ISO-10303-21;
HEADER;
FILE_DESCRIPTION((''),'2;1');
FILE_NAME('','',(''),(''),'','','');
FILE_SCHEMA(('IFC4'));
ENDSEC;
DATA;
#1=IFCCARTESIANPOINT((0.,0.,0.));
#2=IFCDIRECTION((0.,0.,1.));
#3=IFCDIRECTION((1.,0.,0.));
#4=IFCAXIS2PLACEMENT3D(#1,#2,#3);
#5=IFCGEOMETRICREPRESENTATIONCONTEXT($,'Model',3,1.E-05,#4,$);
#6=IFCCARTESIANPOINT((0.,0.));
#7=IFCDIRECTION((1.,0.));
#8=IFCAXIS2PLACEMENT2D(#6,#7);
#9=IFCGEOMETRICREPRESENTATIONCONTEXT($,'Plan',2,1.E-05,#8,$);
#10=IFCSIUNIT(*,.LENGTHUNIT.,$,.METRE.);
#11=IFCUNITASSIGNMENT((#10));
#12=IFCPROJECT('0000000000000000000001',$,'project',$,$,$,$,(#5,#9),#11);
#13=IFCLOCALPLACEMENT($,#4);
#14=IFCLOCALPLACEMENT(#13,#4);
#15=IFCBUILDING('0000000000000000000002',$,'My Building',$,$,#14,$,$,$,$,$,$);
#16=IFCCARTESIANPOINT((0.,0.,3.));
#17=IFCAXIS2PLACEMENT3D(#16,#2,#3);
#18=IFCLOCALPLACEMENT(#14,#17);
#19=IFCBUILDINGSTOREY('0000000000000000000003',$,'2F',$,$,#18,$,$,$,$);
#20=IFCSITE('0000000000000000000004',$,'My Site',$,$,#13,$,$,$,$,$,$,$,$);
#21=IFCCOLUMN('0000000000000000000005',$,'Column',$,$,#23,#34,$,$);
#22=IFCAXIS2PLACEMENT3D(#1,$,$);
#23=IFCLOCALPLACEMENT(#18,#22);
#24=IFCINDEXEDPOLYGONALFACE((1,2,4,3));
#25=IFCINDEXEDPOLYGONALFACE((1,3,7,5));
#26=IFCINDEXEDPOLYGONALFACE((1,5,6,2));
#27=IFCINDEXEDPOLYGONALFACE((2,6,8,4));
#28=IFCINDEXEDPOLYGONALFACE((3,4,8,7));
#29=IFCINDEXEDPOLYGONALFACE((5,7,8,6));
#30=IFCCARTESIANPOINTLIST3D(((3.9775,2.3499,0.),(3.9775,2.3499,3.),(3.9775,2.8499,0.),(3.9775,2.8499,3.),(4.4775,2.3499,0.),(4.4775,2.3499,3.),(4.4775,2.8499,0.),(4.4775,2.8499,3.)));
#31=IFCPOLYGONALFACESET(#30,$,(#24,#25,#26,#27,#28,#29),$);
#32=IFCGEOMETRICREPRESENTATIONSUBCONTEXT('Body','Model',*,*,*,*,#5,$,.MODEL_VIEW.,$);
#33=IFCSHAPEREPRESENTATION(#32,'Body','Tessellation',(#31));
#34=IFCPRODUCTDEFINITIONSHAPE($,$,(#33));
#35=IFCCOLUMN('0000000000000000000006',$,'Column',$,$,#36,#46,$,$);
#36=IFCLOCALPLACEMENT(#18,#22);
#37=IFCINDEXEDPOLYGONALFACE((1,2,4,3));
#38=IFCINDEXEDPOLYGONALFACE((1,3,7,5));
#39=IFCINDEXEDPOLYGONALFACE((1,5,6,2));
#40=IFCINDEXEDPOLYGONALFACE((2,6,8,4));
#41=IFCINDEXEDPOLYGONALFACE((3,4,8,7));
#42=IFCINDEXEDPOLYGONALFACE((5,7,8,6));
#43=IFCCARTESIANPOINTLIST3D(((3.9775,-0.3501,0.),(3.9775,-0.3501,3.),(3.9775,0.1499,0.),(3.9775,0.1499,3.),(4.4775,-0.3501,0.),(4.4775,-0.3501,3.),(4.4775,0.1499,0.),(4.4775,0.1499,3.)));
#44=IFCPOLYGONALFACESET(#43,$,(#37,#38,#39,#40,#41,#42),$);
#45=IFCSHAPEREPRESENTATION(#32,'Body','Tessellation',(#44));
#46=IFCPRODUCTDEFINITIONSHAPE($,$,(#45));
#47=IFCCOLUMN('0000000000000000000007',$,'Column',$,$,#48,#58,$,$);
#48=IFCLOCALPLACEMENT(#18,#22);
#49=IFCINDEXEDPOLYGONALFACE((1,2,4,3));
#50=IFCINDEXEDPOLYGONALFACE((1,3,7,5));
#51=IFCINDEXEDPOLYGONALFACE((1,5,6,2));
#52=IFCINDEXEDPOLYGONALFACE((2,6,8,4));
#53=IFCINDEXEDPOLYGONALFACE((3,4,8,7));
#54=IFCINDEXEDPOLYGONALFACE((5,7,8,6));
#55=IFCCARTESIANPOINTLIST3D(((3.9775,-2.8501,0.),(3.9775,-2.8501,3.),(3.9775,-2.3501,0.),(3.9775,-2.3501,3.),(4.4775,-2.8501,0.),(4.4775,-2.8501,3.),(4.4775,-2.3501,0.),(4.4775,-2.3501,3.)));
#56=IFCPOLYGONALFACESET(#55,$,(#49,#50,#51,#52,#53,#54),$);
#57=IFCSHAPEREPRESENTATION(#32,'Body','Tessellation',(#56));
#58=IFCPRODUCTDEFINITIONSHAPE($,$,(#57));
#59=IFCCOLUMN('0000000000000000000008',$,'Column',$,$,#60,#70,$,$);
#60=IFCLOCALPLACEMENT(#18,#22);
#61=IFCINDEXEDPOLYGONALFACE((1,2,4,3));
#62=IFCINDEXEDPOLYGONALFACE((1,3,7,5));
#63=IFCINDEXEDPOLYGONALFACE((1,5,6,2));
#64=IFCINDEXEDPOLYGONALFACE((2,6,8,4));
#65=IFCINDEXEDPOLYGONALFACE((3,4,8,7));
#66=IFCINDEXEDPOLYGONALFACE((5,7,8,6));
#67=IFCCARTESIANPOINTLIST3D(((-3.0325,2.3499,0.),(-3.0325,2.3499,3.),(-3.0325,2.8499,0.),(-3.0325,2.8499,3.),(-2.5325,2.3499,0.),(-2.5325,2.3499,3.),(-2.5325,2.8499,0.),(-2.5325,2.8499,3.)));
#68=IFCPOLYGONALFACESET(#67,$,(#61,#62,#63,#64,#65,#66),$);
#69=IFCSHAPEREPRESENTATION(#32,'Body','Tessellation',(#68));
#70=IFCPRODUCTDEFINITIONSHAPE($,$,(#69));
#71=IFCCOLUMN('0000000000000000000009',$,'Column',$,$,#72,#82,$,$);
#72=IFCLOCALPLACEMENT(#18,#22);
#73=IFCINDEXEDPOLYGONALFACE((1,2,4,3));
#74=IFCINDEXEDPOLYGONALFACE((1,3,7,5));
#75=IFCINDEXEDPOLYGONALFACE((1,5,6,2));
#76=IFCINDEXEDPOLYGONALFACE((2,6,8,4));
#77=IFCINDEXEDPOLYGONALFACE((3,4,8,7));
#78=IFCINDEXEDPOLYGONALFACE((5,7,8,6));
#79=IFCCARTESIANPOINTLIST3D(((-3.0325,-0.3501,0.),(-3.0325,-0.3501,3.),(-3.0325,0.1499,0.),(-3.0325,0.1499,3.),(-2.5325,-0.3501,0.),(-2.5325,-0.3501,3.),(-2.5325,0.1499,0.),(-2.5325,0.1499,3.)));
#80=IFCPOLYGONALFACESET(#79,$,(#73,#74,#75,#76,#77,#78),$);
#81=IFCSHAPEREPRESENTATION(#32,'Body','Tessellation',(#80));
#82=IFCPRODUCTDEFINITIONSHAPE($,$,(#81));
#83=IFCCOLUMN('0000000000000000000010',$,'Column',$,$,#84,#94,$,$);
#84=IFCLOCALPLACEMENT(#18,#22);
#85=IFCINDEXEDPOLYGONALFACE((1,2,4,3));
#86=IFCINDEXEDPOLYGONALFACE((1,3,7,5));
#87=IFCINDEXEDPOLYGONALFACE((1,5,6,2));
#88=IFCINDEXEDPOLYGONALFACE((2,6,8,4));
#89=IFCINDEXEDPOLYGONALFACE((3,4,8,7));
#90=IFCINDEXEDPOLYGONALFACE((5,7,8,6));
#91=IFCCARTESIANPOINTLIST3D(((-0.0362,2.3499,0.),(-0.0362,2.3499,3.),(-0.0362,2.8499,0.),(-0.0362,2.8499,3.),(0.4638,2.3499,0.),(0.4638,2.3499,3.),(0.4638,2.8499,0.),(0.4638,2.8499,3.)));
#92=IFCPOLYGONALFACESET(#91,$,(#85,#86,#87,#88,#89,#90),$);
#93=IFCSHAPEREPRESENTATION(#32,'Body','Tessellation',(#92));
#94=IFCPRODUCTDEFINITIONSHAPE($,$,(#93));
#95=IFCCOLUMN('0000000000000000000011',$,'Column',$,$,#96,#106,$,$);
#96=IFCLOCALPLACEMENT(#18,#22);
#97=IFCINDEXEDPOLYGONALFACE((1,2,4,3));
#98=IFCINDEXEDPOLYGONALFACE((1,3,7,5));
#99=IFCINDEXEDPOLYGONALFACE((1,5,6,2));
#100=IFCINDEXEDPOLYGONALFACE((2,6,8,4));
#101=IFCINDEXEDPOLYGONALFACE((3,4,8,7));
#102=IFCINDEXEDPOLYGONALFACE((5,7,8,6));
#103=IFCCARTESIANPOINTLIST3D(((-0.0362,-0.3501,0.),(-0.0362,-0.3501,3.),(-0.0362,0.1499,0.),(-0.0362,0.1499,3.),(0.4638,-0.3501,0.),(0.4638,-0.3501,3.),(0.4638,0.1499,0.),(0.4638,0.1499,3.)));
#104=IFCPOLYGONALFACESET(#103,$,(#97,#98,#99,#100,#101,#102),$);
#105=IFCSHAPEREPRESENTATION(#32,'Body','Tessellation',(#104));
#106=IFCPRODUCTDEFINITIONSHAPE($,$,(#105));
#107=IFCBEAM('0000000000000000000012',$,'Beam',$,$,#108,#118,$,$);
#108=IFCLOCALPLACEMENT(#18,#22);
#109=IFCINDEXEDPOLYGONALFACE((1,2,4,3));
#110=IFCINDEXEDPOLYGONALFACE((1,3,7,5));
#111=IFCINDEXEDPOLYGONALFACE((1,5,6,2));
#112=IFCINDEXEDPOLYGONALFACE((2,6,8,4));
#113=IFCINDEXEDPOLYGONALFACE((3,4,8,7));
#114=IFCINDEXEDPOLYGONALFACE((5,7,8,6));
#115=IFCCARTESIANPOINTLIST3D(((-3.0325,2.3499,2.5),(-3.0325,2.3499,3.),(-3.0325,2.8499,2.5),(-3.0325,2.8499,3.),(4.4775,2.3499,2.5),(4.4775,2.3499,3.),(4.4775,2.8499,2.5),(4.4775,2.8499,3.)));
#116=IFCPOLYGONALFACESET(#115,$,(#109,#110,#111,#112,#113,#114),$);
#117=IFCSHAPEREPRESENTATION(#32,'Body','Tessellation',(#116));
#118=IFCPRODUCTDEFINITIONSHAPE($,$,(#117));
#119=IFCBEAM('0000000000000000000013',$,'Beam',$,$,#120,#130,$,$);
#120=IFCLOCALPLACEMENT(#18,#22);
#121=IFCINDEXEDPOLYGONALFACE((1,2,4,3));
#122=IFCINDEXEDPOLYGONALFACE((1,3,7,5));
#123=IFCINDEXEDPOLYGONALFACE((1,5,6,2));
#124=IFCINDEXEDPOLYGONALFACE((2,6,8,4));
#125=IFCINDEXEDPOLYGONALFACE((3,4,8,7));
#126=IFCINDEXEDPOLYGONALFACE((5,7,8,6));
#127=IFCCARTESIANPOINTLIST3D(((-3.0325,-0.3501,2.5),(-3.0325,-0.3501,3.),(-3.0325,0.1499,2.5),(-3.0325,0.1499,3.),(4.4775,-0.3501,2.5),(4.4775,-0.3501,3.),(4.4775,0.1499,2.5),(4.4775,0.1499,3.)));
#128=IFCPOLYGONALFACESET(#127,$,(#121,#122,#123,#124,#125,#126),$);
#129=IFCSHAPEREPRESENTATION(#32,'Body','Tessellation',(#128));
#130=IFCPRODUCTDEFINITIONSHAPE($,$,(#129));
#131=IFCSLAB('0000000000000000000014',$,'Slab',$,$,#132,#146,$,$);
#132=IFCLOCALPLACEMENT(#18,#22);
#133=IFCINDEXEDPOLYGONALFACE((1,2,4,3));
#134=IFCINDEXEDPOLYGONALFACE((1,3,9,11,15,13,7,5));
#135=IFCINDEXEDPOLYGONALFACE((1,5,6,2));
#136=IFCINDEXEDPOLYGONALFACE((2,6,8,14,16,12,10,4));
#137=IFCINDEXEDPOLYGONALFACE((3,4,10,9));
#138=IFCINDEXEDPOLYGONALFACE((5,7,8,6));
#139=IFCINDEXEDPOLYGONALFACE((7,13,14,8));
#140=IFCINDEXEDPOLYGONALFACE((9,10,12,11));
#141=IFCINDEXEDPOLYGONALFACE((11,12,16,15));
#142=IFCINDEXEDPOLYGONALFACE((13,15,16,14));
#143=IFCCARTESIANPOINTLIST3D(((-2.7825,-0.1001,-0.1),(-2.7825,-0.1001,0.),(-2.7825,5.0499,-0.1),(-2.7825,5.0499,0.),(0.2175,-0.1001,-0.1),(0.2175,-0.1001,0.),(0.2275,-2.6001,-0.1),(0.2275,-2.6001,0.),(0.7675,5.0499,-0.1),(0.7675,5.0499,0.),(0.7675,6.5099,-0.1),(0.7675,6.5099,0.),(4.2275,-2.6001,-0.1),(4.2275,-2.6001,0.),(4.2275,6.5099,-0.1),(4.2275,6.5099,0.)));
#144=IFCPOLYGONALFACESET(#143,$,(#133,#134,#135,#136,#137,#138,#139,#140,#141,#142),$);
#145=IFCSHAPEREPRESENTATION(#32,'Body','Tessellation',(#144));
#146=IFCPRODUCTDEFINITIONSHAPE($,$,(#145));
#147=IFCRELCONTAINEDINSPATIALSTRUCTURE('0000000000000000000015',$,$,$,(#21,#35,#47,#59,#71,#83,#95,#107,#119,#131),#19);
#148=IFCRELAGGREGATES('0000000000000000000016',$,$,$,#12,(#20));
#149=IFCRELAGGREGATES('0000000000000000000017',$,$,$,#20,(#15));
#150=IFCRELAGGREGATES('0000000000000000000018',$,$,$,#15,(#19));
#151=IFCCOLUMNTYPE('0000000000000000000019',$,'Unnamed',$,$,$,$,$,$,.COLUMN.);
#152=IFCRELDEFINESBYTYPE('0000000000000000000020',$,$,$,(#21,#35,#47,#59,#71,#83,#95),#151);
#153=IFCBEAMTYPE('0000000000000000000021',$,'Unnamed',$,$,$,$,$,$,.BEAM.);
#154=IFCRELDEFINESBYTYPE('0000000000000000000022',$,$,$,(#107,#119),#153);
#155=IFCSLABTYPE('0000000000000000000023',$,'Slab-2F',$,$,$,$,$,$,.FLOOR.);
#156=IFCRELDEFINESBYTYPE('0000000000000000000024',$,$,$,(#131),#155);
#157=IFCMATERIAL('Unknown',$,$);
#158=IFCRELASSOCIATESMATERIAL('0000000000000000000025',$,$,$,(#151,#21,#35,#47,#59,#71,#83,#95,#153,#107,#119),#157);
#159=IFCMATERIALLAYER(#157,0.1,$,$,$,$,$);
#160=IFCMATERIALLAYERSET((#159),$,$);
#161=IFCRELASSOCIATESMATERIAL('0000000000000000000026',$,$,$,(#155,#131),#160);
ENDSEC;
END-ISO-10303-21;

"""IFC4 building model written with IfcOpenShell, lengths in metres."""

from ifc_helpers import new_model, si_unit, frame, origin_with_axes, origin_2d_with_axis, place, context, subcontext, project, spatial, indexed_curve, rectangle, outline, extrude, material, layer, layer_set, layer_usage, material_profile, profile_set, profile_usage, type_object, element, save


model = new_model("IFC4")

# Units and contexts
model_context = context("Model", 3, precision=1e-05, world=origin_with_axes())
plan_context = context("Plan", 2, precision=1e-05, world=origin_2d_with_axis())
body_context_1 = subcontext(model_context, "Body", "Model", "MODEL_VIEW")
ifc_project = project(units=[si_unit("LENGTHUNIT", "METRE")], contexts=[model_context, plan_context])

# Site, building, storey
site_placement = place(None, origin_with_axes())
site = spatial("IfcSite", under=ifc_project, at=site_placement, Name="My Site")
building_placement = place(site_placement, origin_with_axes())
building = spatial("IfcBuilding", under=site, at=building_placement, Name="My Building")
storey_placement = place(building_placement, frame((0.0, 0.0, 3.0), z_axis=(0.0, 0.0, 1.0), x_axis=(1.0, 0.0, 0.0)))
storey = spatial("IfcBuildingStorey", under=building, at=storey_placement, Name="2F")

# Columns
ifc_material = material(Name="Unknown")
ifc_material_profile_1 = material_profile(ifc_material, rectangle(XDim=0.5, YDim=0.5))
ifc_profile_set_1 = profile_set([ifc_material_profile_1])
ifc_profile_usage_1 = profile_usage(ifc_profile_set_1, cardinal=5)
column_type = type_object("IfcColumnType", Name="Unnamed", PredefinedType="COLUMN", material=ifc_profile_set_1)
column_1_placement = place(storey_placement, frame((4.2275, 2.5999, 0.0), z_axis=(0.0, 0.0, 1.0), x_axis=(1.0, 0.0, 0.0)))
element("IfcColumn", 1, at=column_1_placement, inside=storey, type_object=column_type, material=ifc_profile_usage_1, Name="Column", context=body_context_1, shape_type="SweptSolid", body=[
    extrude(rectangle(XDim=0.5, YDim=0.5), origin_with_axes(), (0.0, 0.0, 1.0), 3.0),
])
ifc_profile_usage_2 = profile_usage(ifc_profile_set_1, cardinal=5)
column_2_placement = place(storey_placement, frame((4.2275, -0.1001, 0.0), z_axis=(0.0, 0.0, 1.0), x_axis=(1.0, 0.0, 0.0)))
element("IfcColumn", 2, at=column_2_placement, inside=storey, type_object=column_type, material=ifc_profile_usage_2, Name="Column", context=body_context_1, shape_type="SweptSolid", body=[
    extrude(rectangle(XDim=0.5, YDim=0.5), origin_with_axes(), (0.0, 0.0, 1.0), 3.0),
])
ifc_profile_usage_3 = profile_usage(ifc_profile_set_1, cardinal=5)
column_3_placement = place(storey_placement, frame((4.2275, -2.6001, 0.0), z_axis=(0.0, 0.0, 1.0), x_axis=(1.0, 0.0, 0.0)))
element("IfcColumn", 3, at=column_3_placement, inside=storey, type_object=column_type, material=ifc_profile_usage_3, Name="Column", context=body_context_1, shape_type="SweptSolid", body=[
    extrude(rectangle(XDim=0.5, YDim=0.5), origin_with_axes(), (0.0, 0.0, 1.0), 3.0),
])
ifc_profile_usage_4 = profile_usage(ifc_profile_set_1, cardinal=5)
column_4_placement = place(storey_placement, frame((-2.7825, 2.5999, 0.0), z_axis=(0.0, 0.0, 1.0), x_axis=(1.0, 0.0, 0.0)))
element("IfcColumn", 4, at=column_4_placement, inside=storey, type_object=column_type, material=ifc_profile_usage_4, Name="Column", context=body_context_1, shape_type="SweptSolid", body=[
    extrude(rectangle(XDim=0.5, YDim=0.5), origin_with_axes(), (0.0, 0.0, 1.0), 3.0),
])
ifc_profile_usage_5 = profile_usage(ifc_profile_set_1, cardinal=5)
column_5_placement = place(storey_placement, frame((-2.7825, -0.1001, 0.0), z_axis=(0.0, 0.0, 1.0), x_axis=(1.0, 0.0, 0.0)))
element("IfcColumn", 5, at=column_5_placement, inside=storey, type_object=column_type, material=ifc_profile_usage_5, Name="Column", context=body_context_1, shape_type="SweptSolid", body=[
    extrude(rectangle(XDim=0.5, YDim=0.5), origin_with_axes(), (0.0, 0.0, 1.0), 3.0),
])
ifc_profile_usage_6 = profile_usage(ifc_profile_set_1, cardinal=5)
column_6_placement = place(storey_placement, frame((0.2138, 2.5999, 0.0), z_axis=(0.0, 0.0, 1.0), x_axis=(1.0, 0.0, 0.0)))
element("IfcColumn", 6, at=column_6_placement, inside=storey, type_object=column_type, material=ifc_profile_usage_6, Name="Column", context=body_context_1, shape_type="SweptSolid", body=[
    extrude(rectangle(XDim=0.5, YDim=0.5), origin_with_axes(), (0.0, 0.0, 1.0), 3.0),
])
ifc_profile_usage_7 = profile_usage(ifc_profile_set_1, cardinal=5)
column_7_placement = place(storey_placement, frame((0.2138, -0.1001, 0.0), z_axis=(0.0, 0.0, 1.0), x_axis=(1.0, 0.0, 0.0)))
element("IfcColumn", 7, at=column_7_placement, inside=storey, type_object=column_type, material=ifc_profile_usage_7, Name="Column", context=body_context_1, shape_type="SweptSolid", body=[
    extrude(rectangle(XDim=0.5, YDim=0.5), origin_with_axes(), (0.0, 0.0, 1.0), 3.0),
])

# Beams
ifc_material_profile_2 = material_profile(ifc_material, rectangle(XDim=0.5, YDim=0.5))
ifc_profile_set_2 = profile_set([ifc_material_profile_2])
ifc_profile_usage_8 = profile_usage(ifc_profile_set_2, cardinal=7)
beam_type = type_object("IfcBeamType", Name="Unnamed", PredefinedType="BEAM", material=ifc_profile_set_2)
beam_1_placement = place(storey_placement, frame((4.4775, 2.3499, 3.0), z_axis=(-1.0, 0.0, 0.0), x_axis=(0.0, -1.0, 0.0)))
element("IfcBeam", 8, at=beam_1_placement, inside=storey, type_object=beam_type, material=ifc_profile_usage_8, Name="Beam", context=body_context_1, shape_type="SweptSolid", body=[
    extrude(rectangle(XDim=0.5, YDim=0.5), frame((-0.25, -0.25, 0.0), z_axis=(0.0, 0.0, 1.0), x_axis=(1.0, 0.0, 0.0)), (0.0, 0.0, 1.0), 7.51),
])
ifc_profile_usage_9 = profile_usage(ifc_profile_set_2, cardinal=7)
beam_2_placement = place(storey_placement, frame((-3.0325, 0.1499, 3.0), z_axis=(1.0, 0.0, 0.0), x_axis=(0.0, 1.0, 0.0)))
element("IfcBeam", 9, at=beam_2_placement, inside=storey, type_object=beam_type, material=ifc_profile_usage_9, Name="Beam", context=body_context_1, shape_type="SweptSolid", body=[
    extrude(rectangle(XDim=0.5, YDim=0.5), frame((-0.25, -0.25, 0.0), z_axis=(0.0, 0.0, 1.0), x_axis=(1.0, 0.0, 0.0)), (0.0, 0.0, 1.0), 7.51),
])

# Slab
ifc_layer_1 = layer(ifc_material, 0.1)
ifc_layer_set_1 = layer_set([ifc_layer_1])
ifc_layer_usage_1 = layer_usage(ifc_layer_set_1, "AXIS3", "POSITIVE", -0.1)
slab_type = type_object("IfcSlabType", Name="Slab-2F", PredefinedType="FLOOR", material=ifc_layer_set_1)
slab_placement = place(storey_placement, frame((4.2275, -2.6001, 0.0), z_axis=(0.0, 0.0, 1.0), x_axis=(1.0, 0.0, 0.0)))
element("IfcSlab", 10, at=slab_placement, inside=storey, type_object=slab_type, material=ifc_layer_usage_1, Name="Slab", context=body_context_1, shape_type="SweptSolid", body=[
    extrude(outline(indexed_curve([(0.0, 0.0), (0.0, 9.11), (-3.46, 9.11), (-3.46, 7.65), (-7.01, 7.65), (-7.01, 2.5), (-4.01, 2.5), (-4.0, 0.0), (0.0, 0.0)])), frame((0.0, 0.0, -0.1), z_axis=(0.0, 0.0, 1.0), x_axis=(1.0, 0.0, 0.0)), (0.0, 0.0, 1.0), 0.1),
])

save(model, "model.ifc")
